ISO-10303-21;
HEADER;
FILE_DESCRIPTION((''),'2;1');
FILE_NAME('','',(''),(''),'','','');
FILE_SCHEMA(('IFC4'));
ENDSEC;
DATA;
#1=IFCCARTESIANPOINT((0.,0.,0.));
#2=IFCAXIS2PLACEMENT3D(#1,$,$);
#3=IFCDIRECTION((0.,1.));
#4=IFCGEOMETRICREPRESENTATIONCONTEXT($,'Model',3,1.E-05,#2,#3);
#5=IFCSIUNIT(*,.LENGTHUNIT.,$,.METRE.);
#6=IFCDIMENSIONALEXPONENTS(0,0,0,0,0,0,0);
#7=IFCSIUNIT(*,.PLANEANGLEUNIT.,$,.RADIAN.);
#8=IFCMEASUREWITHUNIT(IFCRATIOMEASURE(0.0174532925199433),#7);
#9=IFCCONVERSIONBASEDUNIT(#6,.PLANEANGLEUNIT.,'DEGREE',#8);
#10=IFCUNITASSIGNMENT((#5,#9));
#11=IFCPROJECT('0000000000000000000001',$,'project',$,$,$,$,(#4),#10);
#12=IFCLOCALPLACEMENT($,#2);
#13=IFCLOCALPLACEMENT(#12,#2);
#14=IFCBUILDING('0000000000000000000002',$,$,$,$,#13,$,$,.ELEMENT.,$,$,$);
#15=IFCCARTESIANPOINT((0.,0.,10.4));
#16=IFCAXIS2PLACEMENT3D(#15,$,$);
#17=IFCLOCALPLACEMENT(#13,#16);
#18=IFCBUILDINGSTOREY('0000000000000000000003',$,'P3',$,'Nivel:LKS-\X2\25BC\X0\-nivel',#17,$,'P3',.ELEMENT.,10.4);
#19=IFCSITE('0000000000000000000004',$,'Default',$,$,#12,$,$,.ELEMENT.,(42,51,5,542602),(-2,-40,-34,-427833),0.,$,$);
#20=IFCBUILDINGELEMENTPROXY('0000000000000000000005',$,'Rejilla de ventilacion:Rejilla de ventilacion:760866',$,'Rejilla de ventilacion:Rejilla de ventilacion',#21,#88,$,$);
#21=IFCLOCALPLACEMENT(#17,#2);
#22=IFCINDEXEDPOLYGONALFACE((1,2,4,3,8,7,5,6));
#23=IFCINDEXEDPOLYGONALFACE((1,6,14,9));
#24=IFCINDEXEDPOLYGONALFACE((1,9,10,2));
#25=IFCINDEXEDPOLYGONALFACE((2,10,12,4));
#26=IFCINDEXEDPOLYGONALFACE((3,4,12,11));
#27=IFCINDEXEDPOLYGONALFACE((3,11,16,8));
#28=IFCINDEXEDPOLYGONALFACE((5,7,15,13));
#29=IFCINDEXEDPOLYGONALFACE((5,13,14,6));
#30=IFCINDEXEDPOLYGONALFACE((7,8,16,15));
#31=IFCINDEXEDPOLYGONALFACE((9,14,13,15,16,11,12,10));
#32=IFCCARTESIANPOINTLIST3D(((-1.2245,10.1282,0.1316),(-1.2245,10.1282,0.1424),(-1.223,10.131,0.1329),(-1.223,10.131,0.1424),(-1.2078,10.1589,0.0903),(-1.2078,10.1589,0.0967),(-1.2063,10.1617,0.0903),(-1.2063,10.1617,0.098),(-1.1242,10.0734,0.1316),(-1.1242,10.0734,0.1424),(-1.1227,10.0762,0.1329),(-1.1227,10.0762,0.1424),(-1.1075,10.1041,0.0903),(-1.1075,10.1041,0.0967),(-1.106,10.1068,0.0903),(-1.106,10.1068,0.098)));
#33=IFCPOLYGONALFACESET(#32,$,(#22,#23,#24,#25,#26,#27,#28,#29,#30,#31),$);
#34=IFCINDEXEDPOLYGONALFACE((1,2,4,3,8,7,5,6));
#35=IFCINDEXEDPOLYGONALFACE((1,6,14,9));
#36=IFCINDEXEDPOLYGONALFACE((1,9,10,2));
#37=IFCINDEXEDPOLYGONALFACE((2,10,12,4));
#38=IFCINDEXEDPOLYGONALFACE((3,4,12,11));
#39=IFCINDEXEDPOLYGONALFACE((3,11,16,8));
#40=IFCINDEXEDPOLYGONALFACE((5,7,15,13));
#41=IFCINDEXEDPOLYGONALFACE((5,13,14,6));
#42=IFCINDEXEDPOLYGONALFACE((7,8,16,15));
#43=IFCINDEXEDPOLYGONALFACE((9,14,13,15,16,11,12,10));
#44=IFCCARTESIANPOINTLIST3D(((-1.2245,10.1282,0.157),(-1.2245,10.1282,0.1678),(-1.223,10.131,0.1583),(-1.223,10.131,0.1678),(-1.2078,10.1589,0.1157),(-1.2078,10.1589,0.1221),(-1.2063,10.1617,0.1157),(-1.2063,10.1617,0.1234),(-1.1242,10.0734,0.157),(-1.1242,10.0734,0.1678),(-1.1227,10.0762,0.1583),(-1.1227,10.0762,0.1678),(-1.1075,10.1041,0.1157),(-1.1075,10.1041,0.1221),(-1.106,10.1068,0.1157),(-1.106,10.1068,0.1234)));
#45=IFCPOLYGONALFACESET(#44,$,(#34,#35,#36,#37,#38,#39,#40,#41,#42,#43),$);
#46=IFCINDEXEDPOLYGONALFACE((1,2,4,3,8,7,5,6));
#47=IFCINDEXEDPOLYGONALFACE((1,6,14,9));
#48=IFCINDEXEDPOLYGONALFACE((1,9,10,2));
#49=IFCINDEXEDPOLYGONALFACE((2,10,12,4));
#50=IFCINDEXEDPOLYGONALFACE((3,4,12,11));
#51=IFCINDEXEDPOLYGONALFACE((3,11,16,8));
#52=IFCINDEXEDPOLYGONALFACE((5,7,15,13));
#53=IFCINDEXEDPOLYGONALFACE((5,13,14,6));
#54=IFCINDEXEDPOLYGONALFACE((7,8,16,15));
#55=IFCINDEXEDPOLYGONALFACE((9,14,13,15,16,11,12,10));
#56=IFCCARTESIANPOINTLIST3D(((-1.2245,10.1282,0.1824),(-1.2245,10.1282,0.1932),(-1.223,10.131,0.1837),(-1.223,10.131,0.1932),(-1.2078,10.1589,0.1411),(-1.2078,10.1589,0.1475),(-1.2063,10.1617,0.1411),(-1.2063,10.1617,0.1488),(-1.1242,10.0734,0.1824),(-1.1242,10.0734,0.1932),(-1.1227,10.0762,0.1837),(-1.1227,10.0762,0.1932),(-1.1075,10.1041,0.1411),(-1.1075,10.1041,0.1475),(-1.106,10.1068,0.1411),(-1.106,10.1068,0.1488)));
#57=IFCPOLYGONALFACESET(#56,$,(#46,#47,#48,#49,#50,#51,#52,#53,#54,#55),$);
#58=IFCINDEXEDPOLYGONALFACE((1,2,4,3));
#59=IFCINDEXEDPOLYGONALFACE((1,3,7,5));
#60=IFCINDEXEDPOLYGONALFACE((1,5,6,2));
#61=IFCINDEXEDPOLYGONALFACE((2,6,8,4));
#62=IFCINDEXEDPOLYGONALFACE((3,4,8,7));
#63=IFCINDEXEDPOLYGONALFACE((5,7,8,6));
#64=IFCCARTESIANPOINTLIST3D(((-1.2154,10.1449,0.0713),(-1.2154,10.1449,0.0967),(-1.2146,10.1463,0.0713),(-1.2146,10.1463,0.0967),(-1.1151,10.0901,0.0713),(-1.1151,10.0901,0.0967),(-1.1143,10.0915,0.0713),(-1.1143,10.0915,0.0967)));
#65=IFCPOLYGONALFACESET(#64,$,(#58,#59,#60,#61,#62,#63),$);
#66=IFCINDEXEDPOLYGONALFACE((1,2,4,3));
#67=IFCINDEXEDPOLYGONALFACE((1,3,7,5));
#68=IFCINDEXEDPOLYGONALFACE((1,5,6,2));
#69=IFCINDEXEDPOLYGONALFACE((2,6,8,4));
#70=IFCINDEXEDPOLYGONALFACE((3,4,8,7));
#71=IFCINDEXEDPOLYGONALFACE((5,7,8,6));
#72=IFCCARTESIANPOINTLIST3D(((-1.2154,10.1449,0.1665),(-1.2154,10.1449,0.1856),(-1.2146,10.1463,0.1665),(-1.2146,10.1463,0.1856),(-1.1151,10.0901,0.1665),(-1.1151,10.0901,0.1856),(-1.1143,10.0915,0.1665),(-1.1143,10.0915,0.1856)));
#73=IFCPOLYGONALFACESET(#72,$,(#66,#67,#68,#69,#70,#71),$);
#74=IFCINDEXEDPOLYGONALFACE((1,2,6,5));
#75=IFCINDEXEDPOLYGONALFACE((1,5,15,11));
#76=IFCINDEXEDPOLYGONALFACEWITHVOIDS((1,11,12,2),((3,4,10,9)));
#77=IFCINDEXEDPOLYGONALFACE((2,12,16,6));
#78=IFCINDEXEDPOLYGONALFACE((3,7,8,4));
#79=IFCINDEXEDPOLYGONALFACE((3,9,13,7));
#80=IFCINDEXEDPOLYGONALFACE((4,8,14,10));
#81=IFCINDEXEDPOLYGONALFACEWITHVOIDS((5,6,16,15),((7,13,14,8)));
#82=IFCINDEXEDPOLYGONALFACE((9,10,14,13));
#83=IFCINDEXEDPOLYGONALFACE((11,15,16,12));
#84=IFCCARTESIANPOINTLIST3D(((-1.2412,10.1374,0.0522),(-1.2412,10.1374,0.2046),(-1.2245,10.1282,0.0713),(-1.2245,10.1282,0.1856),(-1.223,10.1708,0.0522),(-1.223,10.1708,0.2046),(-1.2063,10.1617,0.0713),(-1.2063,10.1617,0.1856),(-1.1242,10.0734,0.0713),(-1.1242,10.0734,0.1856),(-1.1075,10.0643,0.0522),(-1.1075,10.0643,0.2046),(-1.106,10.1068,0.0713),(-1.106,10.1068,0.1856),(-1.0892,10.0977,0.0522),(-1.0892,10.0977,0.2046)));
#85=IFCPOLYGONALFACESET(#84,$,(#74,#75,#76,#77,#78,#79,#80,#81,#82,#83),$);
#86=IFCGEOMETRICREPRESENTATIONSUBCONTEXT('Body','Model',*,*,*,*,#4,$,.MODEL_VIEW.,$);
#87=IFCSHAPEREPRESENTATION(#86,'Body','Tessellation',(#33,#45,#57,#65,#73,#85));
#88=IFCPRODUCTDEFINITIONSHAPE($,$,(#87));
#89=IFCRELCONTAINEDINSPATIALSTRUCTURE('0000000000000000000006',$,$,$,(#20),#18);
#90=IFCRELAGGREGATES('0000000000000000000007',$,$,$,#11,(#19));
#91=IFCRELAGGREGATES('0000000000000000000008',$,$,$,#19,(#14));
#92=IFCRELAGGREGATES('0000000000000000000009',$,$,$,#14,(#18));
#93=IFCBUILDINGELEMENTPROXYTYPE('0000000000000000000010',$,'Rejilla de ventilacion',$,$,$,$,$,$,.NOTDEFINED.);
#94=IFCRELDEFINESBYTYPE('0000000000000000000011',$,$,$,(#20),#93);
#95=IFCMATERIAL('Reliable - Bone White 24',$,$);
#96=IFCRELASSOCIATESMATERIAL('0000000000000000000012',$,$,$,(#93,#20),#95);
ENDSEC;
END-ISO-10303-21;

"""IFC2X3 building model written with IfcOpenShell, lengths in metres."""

from ifc_helpers import new_model, entity, si_unit, converted_unit, direction, frame, frame_2d, origin, place, context, subcontext, project, spatial, polyline, rectangle, outline, extrude, source, transform, mapped, material, type_object, type_shapes, element, save


model = new_model("IFC2X3")

# Units and contexts
model_context = context("Model", 3, precision=1e-05, world=origin(), true_north=direction((0.0, 1.0)))
body_context = subcontext(model_context, "Body", "Model", "MODEL_VIEW")
ifc_project = project(units=[si_unit("LENGTHUNIT", "METRE"), converted_unit("PLANEANGLEUNIT", "DEGREE", entity("IfcRatioMeasure", 0.0174532925199433), si_unit("PLANEANGLEUNIT", "RADIAN"), dimensions=[0, 0, 0, 0, 0, 0, 0])], contexts=[model_context])

# Site, building, storey
site_placement = place(None, origin())
site = spatial("IfcSite", under=ifc_project, at=site_placement, Name="Default", CompositionType="ELEMENT", RefLatitude=(42, 51, 5, 542602), RefLongitude=(-2, -40, -34, -427833), RefElevation=0.0)
building_placement = place(site_placement, origin())
building = spatial("IfcBuilding", under=site, at=building_placement, CompositionType="ELEMENT")
storey_placement = place(building_placement, frame((0.0, 0.0, 10.4)))
storey = spatial("IfcBuildingStorey", under=building, at=storey_placement, Name="P3", ObjectType="Nivel:LKS-▼-nivel", LongName="P3", CompositionType="ELEMENT", Elevation=10.4)

# Building element proxy
ifc_material_1 = material(Name="Reliable - Bone White 24")
building_element_proxy_type = type_object("IfcBuildingElementProxyType", Name="Rejilla de ventilacion", PredefinedType="NOTDEFINED", material=ifc_material_1)
shared_shape = source(origin(), body_context, "Body", "SweptSolid", [
    extrude(outline(polyline([(0.0173, 0.0159), (0.0269, 0.0159), (0.0269, 0.0191), (0.016, 0.0191), (-0.0189, -0.0159), (-0.0253, -0.0159), (-0.0253, -0.019), (-0.0176, -0.019), (0.0173, 0.0159)])), frame((-0.0571, 0.06, 1.435), z_axis=(1.0, 0.0, 0.0), x_axis=(0.0, 0.0, 1.0)), (0.0, 0.0, 1.0), 0.1143),
    extrude(outline(polyline([(0.0173, 0.0159), (0.0269, 0.0159), (0.0269, 0.0191), (0.016, 0.0191), (-0.0189, -0.0159), (-0.0253, -0.0159), (-0.0253, -0.019), (-0.0176, -0.019), (0.0173, 0.0159)])), frame((-0.0571, 0.06, 1.4604), z_axis=(1.0, 0.0, 0.0), x_axis=(0.0, 0.0, 1.0)), (0.0, 0.0, 1.0), 0.1143),
    extrude(outline(polyline([(0.0173, 0.0159), (0.0269, 0.0159), (0.0269, 0.0191), (0.016, 0.0191), (-0.0189, -0.0159), (-0.0253, -0.0159), (-0.0253, -0.019), (-0.0176, -0.019), (0.0173, 0.0159)])), frame((-0.0571, 0.06, 1.4858), z_axis=(1.0, 0.0, 0.0), x_axis=(0.0, 0.0, 1.0)), (0.0, 0.0, 1.0), 0.1143),
    extrude(rectangle(XDim=0.1143, YDim=0.0016, at=frame_2d((0.0, 0.0), x_axis=(1.0, 0.0))), frame((0.0, 0.0607, 1.3906), z_axis=(0.0, 0.0, 1.0), x_axis=(-1.0, 0.0, 0.0)), (0.0, 0.0, 1.0), 0.0254),
    extrude(rectangle(XDim=0.1143, YDim=0.0016, at=frame_2d((0.0, 0.0), x_axis=(1.0, 0.0))), frame((0.0, 0.0607, 1.4859), z_axis=(0.0, 0.0, 1.0), x_axis=(-1.0, 0.0, 0.0)), (0.0, 0.0, 1.0), 0.0191),
    extrude(outline(polyline([(-0.0762, -0.0762), (0.0762, -0.0762), (0.0762, 0.0762), (-0.0762, 0.0762), (-0.0762, -0.0762)]), holes=[polyline([(-0.0572, -0.0572), (-0.0572, 0.0572), (0.0572, 0.0572), (0.0572, -0.0572), (-0.0572, -0.0572)])]), frame((0.0, 0.0409, 1.4478), z_axis=(0.0, 1.0, 0.0), x_axis=(0.0, 0.0, 1.0)), (0.0, 0.0, 1.0), 0.0381),
])
type_shapes(building_element_proxy_type, [shared_shape])
proxy_placement = place(storey_placement, frame((-1.194, 10.0649, -1.3194), z_axis=(0.0, 0.0, 1.0), x_axis=(0.877509, -0.479561, 0.0)))
element("IfcBuildingElementProxy", 1, at=proxy_placement, inside=storey, type_object=building_element_proxy_type, material=ifc_material_1, Name="Rejilla de ventilacion:Rejilla de ventilacion:760866", ObjectType="Rejilla de ventilacion:Rejilla de ventilacion", context=body_context, shape_type="MappedRepresentation", body=[
    mapped(shared_shape, transform((0.0, 0.0, 0.0), scale=1.0)),
])

save(model, "model.ifc")
